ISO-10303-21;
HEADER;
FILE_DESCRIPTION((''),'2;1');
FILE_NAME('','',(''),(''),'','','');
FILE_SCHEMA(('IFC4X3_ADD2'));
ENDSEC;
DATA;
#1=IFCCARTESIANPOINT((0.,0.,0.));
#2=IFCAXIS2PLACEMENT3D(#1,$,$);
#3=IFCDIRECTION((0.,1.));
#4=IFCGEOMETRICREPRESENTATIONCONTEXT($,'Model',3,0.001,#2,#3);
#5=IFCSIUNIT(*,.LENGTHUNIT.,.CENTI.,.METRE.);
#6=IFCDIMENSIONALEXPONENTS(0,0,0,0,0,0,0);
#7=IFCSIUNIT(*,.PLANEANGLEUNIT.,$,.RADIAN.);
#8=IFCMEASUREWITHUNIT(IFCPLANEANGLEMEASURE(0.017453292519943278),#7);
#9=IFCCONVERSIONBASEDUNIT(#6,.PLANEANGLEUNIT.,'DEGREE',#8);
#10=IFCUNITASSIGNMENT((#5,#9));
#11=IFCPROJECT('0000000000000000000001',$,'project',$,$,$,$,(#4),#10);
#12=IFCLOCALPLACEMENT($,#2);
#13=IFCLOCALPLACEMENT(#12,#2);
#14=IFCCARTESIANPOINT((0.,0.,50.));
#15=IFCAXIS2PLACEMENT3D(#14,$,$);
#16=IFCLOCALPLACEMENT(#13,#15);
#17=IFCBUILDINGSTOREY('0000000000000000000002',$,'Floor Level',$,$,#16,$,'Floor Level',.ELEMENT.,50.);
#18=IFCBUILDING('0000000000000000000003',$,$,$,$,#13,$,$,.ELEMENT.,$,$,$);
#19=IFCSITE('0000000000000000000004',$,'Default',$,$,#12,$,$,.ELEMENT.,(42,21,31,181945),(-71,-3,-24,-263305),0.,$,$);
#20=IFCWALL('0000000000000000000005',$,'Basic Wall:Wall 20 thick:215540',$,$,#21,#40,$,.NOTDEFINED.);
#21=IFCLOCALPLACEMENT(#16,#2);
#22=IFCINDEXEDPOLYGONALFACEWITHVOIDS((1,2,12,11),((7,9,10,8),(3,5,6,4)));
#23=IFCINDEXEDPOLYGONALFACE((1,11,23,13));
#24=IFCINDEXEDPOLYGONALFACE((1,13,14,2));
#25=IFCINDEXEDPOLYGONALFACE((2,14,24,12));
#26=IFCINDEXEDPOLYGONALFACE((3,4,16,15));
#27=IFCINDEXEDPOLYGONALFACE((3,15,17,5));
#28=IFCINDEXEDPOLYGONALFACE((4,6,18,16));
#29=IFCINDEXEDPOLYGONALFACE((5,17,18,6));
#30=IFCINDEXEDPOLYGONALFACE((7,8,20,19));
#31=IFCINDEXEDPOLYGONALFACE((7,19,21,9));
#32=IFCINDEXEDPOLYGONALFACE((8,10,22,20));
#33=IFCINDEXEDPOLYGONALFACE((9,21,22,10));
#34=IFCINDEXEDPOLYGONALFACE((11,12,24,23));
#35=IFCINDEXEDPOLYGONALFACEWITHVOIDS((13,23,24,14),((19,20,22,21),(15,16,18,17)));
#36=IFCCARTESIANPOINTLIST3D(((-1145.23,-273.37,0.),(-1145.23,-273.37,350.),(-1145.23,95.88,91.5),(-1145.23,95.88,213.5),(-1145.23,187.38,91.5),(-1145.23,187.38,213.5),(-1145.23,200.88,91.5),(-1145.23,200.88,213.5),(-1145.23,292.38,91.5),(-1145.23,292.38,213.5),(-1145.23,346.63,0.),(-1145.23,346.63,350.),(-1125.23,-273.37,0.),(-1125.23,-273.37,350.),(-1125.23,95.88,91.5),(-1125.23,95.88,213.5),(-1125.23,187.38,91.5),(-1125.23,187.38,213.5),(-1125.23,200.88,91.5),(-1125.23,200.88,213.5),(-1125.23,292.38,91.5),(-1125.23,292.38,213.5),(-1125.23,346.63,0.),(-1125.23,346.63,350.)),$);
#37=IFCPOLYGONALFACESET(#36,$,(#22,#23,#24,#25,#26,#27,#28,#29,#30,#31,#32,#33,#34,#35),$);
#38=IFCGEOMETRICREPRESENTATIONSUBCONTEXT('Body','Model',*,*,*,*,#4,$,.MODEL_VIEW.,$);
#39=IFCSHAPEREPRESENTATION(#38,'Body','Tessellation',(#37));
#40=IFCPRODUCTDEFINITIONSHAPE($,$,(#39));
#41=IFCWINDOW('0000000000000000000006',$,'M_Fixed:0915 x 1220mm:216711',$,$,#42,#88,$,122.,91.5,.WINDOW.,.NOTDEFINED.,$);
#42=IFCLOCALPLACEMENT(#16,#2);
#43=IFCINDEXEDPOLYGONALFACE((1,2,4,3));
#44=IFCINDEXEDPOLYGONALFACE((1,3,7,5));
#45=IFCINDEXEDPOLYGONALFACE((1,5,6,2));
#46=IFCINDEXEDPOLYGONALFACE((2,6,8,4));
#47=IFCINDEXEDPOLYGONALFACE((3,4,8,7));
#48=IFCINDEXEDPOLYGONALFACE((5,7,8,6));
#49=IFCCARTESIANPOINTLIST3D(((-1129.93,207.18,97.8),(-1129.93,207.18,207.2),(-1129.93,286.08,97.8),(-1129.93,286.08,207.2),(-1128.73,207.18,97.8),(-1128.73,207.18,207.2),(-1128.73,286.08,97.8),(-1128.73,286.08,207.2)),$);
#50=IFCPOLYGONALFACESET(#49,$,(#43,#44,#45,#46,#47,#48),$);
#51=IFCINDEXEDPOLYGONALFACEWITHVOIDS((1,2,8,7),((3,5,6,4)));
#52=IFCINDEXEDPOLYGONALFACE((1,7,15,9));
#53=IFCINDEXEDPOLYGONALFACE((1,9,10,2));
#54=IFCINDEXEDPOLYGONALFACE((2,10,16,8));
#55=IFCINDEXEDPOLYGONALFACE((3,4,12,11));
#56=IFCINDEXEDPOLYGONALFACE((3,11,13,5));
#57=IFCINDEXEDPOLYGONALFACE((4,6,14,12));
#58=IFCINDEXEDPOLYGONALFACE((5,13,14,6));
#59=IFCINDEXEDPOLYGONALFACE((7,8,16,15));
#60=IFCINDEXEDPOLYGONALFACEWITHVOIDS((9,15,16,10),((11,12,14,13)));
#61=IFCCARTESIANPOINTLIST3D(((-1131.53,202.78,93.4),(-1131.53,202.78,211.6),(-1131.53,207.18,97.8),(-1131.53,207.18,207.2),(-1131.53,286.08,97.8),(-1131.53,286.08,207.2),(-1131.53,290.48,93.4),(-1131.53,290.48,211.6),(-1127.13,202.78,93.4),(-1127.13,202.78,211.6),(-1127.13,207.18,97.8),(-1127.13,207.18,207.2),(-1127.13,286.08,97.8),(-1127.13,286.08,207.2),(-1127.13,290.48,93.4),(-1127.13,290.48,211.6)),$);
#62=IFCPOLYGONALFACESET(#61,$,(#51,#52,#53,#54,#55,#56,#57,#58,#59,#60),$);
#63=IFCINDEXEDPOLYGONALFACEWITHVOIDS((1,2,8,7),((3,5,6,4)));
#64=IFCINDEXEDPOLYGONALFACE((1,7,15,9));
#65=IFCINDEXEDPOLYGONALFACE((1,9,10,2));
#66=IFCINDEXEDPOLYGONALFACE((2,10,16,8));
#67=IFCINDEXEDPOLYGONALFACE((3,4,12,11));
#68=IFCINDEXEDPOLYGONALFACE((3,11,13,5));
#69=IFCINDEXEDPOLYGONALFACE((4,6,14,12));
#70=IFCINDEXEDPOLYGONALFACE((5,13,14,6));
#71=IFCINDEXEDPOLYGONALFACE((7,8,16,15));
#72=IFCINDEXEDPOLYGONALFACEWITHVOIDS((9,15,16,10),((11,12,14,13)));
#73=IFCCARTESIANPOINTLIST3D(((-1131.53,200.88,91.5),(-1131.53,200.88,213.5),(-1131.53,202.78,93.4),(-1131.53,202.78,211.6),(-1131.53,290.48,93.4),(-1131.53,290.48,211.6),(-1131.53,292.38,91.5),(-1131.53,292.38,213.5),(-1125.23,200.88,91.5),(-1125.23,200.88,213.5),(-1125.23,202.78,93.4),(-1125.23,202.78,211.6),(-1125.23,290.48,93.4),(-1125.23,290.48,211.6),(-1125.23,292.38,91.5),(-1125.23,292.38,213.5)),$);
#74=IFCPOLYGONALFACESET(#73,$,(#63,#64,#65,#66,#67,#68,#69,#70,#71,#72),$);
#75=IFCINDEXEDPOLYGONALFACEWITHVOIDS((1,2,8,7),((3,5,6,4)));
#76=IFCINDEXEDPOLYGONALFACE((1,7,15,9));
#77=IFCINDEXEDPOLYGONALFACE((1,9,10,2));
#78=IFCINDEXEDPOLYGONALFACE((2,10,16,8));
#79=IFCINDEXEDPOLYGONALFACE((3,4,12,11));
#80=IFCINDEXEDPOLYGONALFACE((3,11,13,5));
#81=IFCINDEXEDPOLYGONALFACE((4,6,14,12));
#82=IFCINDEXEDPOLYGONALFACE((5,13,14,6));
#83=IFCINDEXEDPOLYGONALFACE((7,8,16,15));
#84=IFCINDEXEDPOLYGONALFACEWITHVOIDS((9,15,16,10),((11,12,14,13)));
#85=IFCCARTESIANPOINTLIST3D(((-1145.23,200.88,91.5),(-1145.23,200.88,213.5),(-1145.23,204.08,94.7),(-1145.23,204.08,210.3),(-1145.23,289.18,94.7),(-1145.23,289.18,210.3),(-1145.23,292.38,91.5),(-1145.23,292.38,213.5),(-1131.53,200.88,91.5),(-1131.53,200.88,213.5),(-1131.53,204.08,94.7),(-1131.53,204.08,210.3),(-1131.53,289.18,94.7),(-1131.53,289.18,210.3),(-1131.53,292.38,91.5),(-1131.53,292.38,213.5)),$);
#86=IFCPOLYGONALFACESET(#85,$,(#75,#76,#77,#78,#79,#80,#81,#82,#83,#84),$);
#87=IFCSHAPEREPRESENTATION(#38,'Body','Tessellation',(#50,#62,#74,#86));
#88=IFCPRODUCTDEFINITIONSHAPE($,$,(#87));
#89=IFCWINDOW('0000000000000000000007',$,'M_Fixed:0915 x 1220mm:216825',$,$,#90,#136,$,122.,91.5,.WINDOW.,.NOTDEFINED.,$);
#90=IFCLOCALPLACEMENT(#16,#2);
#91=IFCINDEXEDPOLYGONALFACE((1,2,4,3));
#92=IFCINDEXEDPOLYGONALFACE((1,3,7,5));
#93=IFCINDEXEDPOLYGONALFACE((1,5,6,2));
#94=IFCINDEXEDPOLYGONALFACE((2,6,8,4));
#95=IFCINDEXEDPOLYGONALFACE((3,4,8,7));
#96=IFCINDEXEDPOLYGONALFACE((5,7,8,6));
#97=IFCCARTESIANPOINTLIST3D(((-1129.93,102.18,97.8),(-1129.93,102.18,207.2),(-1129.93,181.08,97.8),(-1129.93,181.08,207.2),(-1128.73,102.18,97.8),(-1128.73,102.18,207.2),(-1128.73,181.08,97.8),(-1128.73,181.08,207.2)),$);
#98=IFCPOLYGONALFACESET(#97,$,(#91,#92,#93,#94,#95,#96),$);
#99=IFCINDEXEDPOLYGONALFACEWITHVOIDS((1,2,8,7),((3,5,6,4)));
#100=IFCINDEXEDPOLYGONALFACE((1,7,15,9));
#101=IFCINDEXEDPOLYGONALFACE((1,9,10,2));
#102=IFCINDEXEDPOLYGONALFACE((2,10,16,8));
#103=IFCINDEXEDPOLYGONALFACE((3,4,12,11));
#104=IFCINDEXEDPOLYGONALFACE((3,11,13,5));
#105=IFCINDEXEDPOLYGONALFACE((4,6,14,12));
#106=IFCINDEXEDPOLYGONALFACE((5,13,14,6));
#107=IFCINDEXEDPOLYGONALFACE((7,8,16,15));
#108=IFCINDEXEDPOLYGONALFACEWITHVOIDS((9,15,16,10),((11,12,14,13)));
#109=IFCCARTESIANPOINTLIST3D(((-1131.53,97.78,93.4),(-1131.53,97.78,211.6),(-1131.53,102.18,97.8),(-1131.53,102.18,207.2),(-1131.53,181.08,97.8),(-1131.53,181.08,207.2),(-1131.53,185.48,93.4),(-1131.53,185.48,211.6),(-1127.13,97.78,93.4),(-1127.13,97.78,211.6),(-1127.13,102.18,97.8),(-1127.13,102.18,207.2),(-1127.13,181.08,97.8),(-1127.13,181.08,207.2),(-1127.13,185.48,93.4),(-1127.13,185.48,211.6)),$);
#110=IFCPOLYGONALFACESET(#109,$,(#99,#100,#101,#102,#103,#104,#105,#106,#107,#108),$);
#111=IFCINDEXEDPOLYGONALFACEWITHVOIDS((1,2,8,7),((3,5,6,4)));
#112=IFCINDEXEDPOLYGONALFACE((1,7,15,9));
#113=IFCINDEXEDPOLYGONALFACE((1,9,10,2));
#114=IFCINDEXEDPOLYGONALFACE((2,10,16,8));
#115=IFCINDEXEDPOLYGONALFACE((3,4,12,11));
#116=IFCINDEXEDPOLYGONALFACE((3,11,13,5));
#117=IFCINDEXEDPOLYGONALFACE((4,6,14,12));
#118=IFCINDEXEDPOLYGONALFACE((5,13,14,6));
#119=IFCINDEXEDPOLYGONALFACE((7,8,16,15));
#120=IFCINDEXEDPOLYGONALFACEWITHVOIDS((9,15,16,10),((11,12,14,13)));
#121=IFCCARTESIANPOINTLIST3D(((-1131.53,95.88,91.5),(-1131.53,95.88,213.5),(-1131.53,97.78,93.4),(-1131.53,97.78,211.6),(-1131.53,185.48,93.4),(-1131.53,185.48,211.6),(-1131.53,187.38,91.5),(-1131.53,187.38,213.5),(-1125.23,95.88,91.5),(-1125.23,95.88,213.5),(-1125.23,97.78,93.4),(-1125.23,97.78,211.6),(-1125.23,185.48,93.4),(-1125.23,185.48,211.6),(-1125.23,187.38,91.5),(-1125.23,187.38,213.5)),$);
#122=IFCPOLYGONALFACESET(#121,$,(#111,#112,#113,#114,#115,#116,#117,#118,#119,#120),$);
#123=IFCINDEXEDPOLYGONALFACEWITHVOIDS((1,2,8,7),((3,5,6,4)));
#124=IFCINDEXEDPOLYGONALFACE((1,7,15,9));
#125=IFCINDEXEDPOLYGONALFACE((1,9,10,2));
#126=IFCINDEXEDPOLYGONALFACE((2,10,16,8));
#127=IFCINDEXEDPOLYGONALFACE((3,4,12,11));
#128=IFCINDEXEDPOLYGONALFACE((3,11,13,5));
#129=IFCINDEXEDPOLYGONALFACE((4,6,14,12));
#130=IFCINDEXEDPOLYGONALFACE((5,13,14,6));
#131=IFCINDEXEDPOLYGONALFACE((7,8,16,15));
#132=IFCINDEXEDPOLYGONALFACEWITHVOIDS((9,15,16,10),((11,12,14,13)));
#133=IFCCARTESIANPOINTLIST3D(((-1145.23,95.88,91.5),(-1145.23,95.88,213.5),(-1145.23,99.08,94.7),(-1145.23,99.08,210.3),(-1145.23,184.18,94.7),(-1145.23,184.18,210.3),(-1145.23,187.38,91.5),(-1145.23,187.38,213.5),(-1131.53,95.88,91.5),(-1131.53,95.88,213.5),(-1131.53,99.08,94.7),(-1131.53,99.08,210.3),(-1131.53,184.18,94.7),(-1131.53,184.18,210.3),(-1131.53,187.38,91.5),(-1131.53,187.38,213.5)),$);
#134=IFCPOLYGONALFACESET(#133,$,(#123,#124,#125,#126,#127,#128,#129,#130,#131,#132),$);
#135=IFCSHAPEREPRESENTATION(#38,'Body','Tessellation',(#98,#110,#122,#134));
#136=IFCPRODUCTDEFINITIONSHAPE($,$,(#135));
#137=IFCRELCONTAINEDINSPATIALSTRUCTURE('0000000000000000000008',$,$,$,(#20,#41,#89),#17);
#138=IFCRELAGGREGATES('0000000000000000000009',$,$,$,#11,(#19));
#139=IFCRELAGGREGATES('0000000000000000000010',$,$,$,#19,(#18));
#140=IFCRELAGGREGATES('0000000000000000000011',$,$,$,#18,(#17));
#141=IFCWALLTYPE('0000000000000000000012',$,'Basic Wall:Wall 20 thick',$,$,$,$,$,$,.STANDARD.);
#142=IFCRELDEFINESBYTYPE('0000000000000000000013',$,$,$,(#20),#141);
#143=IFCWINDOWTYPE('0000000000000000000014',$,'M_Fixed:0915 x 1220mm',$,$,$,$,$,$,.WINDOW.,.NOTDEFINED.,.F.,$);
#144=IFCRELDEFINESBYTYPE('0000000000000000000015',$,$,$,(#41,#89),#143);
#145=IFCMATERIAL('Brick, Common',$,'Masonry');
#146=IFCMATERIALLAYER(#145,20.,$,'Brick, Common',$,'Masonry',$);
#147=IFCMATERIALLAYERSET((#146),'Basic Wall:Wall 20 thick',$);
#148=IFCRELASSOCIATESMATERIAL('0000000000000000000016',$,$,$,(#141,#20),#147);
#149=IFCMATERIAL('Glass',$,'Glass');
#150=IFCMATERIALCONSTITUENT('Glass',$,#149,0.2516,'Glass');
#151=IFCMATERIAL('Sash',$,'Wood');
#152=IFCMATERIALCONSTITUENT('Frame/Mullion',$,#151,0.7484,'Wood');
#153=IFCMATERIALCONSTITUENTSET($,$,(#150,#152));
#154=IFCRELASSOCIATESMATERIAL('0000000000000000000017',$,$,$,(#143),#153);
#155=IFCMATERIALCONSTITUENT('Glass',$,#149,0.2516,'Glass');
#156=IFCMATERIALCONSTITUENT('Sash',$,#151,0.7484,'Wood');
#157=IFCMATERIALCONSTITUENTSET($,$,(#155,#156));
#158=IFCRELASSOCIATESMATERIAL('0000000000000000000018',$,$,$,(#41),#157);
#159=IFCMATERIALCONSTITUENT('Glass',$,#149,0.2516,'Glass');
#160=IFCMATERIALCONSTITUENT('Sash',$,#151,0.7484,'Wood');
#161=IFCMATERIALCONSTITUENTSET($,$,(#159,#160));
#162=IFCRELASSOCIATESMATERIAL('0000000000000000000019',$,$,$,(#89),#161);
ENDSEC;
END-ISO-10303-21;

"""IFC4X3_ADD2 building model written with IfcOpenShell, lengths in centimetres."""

from ifc_helpers import new_model, entity, si_unit, converted_unit, direction, frame, frame_2d, origin, place, context, subcontext, project, spatial, polyline, rectangle, outline, extrude, source, transform, mapped, material, layer, layer_set, constituent, constituent_set, type_object, type_shapes, element, fill, save


model = new_model("IFC4X3_ADD2")

# Units and contexts
model_context = context("Model", 3, precision=0.001, world=origin(), true_north=direction((0.0, 1.0)))
body_context = subcontext(model_context, "Body", "Model", "MODEL_VIEW")
ifc_project = project(units=[si_unit("LENGTHUNIT", "METRE", prefix="CENTI"), converted_unit("PLANEANGLEUNIT", "DEGREE", entity("IfcPlaneAngleMeasure", 0.017453292519943278), si_unit("PLANEANGLEUNIT", "RADIAN"), dimensions=[0, 0, 0, 0, 0, 0, 0])], contexts=[model_context])

# Site, building, storey
site_placement = place(None, origin())
site = spatial("IfcSite", under=ifc_project, at=site_placement, Name="Default", CompositionType="ELEMENT", RefLatitude=(42, 21, 31, 181945), RefLongitude=(-71, -3, -24, -263305), RefElevation=0.0)
building_placement = place(site_placement, origin())
building = spatial("IfcBuilding", under=site, at=building_placement, CompositionType="ELEMENT")
storey_placement = place(building_placement, frame((0.0, 0.0, 50.0)))
storey = spatial("IfcBuildingStorey", under=building, at=storey_placement, Name="Floor Level", LongName="Floor Level", CompositionType="ELEMENT", Elevation=50.0)

# Wall, openings, windows
ifc_material_1 = material(Name="Brick, Common", Category="Masonry")
ifc_layer = layer(ifc_material_1, 20.0, Name="Brick, Common", Category="Masonry")
ifc_layer_set = layer_set([ifc_layer], Name="Basic Wall:Wall 20 thick")
wall_type = type_object("IfcWallType", Name="Basic Wall:Wall 20 thick", PredefinedType="STANDARD", material=ifc_layer_set)
wall_1_placement = place(storey_placement, frame((-1135.23, 346.63, 0.0), z_axis=(0.0, 0.0, 1.0), x_axis=(0.0, -1.0, 0.0)))
wall_1 = element("IfcWall", 1, at=wall_1_placement, inside=storey, type_object=wall_type, material=ifc_layer_set, Name="Basic Wall:Wall 20 thick:215540", PredefinedType="NOTDEFINED", context=body_context, shape_type="SweptSolid", body=[
    extrude(rectangle(XDim=620.0, YDim=20.0, at=frame_2d((310.0, 0.0), x_axis=(-1.0, 0.0))), origin(), (0.0, 0.0, 1.0), 350.0),
])
opening_1_placement = place(wall_1_placement, frame((54.25, -10.0, 91.5)))
opening_1 = element("IfcOpeningElement", 2, at=opening_1_placement, cuts=wall_1, PredefinedType="OPENING", context=body_context, shape_type="SweptSolid", body=[
    extrude(rectangle(XDim=122.0, YDim=91.5, at=frame_2d((61.0, 45.75), x_axis=(1.0, 0.0))), frame((0.0, 0.0, 0.0), z_axis=(0.0, 1.0, 0.0), x_axis=(0.0, 0.0, 1.0)), (0.0, 0.0, 1.0), 20.0),
])
opening_2_placement = place(wall_1_placement, frame((159.25, -10.0, 91.5)))
opening_2 = element("IfcOpeningElement", 3, at=opening_2_placement, cuts=wall_1, PredefinedType="OPENING", context=body_context, shape_type="SweptSolid", body=[
    extrude(rectangle(XDim=122.0, YDim=91.5, at=frame_2d((61.0, 45.75), x_axis=(1.0, 0.0))), frame((0.0, 0.0, 0.0), z_axis=(0.0, 1.0, 0.0), x_axis=(0.0, 0.0, 1.0)), (0.0, 0.0, 1.0), 20.0),
])
ifc_material_2 = material(Name="Glass", Category="Glass")
ifc_constituent_1 = constituent(ifc_material_2, Name="Glass", Category="Glass", fraction=0.2516)
ifc_material_3 = material(Name="Sash", Category="Wood")
ifc_constituent_2 = constituent(ifc_material_3, Name="Sash", Category="Wood", fraction=0.7484)
ifc_constituent_set_1 = constituent_set(constituents=[ifc_constituent_1, ifc_constituent_2])
ifc_constituent_3 = constituent(ifc_material_2, Name="Glass", Category="Glass", fraction=0.2516)
ifc_constituent_4 = constituent(ifc_material_3, Name="Frame/Mullion", Category="Wood", fraction=0.7484)
ifc_constituent_set_2 = constituent_set(constituents=[ifc_constituent_3, ifc_constituent_4])
window_type = type_object("IfcWindowType", Name="M_Fixed:0915 x 1220mm", ParameterTakesPrecedence=False, PartitioningType="NOTDEFINED", PredefinedType="WINDOW", material=ifc_constituent_set_2)
shared_shape_1 = source(origin(), body_context, "Body", "SweptSolid", [
    extrude(rectangle(XDim=1.2, YDim=78.9, at=frame_2d((0.0, 0.0), x_axis=(1.0, 0.0))), frame((45.75, 15.9, 6.3), z_axis=(0.0, 0.0, 1.0), x_axis=(0.0, -1.0, 0.0)), (0.0, 0.0, 1.0), 109.4),
    extrude(outline(polyline([(-43.85, -59.1), (43.85, -59.1), (43.85, 59.1), (-43.85, 59.1), (-43.85, -59.1)]), holes=[polyline([(-39.45, -54.7), (-39.45, 54.7), (39.45, 54.7), (39.45, -54.7), (-39.45, -54.7)])]), frame((45.75, 13.7, 61.0), z_axis=(0.0, 1.0, 0.0), x_axis=(1.0, 0.0, 0.0)), (0.0, 0.0, 1.0), 4.4),
    extrude(outline(polyline([(-45.75, -61.0), (45.75, -61.0), (45.75, 61.0), (-45.75, 61.0), (-45.75, -61.0)]), holes=[polyline([(-43.85, -59.1), (-43.85, 59.1), (43.85, 59.1), (43.85, -59.1), (-43.85, -59.1)])]), frame((45.75, 13.7, 61.0), z_axis=(0.0, 1.0, 0.0), x_axis=(1.0, 0.0, 0.0)), (0.0, 0.0, 1.0), 6.3),
    extrude(outline(polyline([(-45.75, -61.0), (45.75, -61.0), (45.75, 61.0), (-45.75, 61.0), (-45.75, -61.0)]), holes=[polyline([(-42.55, -57.8), (-42.55, 57.8), (42.55, 57.8), (42.55, -57.8), (-42.55, -57.8)])]), frame((45.75, 0.0, 61.0), z_axis=(0.0, 1.0, 0.0), x_axis=(1.0, 0.0, 0.0)), (0.0, 0.0, 1.0), 13.7),
])
type_shapes(window_type, [shared_shape_1])
window_1_placement = place(opening_1_placement, origin())
window_1 = element("IfcWindow", 4, at=window_1_placement, inside=storey, type_object=window_type, material=ifc_constituent_set_1, Name="M_Fixed:0915 x 1220mm:216711", OverallHeight=122.0, OverallWidth=91.5, PartitioningType="NOTDEFINED", PredefinedType="WINDOW", context=body_context, shape_type="MappedRepresentation", body=[
    mapped(shared_shape_1, transform((0.0, 0.0, 0.0), scale=1.0)),
])
fill(opening_1, window_1)
ifc_constituent_5 = constituent(ifc_material_2, Name="Glass", Category="Glass", fraction=0.2516)
ifc_constituent_6 = constituent(ifc_material_3, Name="Sash", Category="Wood", fraction=0.7484)
ifc_constituent_set_3 = constituent_set(constituents=[ifc_constituent_5, ifc_constituent_6])
window_2_placement = place(opening_2_placement, origin())
window_2 = element("IfcWindow", 5, at=window_2_placement, inside=storey, type_object=window_type, material=ifc_constituent_set_3, Name="M_Fixed:0915 x 1220mm:216825", OverallHeight=122.0, OverallWidth=91.5, PartitioningType="NOTDEFINED", PredefinedType="WINDOW", context=body_context, shape_type="MappedRepresentation", body=[
    mapped(shared_shape_1, transform((0.0, 0.0, 0.0), scale=1.0)),
])
fill(opening_2, window_2)

save(model, "model.ifc")
